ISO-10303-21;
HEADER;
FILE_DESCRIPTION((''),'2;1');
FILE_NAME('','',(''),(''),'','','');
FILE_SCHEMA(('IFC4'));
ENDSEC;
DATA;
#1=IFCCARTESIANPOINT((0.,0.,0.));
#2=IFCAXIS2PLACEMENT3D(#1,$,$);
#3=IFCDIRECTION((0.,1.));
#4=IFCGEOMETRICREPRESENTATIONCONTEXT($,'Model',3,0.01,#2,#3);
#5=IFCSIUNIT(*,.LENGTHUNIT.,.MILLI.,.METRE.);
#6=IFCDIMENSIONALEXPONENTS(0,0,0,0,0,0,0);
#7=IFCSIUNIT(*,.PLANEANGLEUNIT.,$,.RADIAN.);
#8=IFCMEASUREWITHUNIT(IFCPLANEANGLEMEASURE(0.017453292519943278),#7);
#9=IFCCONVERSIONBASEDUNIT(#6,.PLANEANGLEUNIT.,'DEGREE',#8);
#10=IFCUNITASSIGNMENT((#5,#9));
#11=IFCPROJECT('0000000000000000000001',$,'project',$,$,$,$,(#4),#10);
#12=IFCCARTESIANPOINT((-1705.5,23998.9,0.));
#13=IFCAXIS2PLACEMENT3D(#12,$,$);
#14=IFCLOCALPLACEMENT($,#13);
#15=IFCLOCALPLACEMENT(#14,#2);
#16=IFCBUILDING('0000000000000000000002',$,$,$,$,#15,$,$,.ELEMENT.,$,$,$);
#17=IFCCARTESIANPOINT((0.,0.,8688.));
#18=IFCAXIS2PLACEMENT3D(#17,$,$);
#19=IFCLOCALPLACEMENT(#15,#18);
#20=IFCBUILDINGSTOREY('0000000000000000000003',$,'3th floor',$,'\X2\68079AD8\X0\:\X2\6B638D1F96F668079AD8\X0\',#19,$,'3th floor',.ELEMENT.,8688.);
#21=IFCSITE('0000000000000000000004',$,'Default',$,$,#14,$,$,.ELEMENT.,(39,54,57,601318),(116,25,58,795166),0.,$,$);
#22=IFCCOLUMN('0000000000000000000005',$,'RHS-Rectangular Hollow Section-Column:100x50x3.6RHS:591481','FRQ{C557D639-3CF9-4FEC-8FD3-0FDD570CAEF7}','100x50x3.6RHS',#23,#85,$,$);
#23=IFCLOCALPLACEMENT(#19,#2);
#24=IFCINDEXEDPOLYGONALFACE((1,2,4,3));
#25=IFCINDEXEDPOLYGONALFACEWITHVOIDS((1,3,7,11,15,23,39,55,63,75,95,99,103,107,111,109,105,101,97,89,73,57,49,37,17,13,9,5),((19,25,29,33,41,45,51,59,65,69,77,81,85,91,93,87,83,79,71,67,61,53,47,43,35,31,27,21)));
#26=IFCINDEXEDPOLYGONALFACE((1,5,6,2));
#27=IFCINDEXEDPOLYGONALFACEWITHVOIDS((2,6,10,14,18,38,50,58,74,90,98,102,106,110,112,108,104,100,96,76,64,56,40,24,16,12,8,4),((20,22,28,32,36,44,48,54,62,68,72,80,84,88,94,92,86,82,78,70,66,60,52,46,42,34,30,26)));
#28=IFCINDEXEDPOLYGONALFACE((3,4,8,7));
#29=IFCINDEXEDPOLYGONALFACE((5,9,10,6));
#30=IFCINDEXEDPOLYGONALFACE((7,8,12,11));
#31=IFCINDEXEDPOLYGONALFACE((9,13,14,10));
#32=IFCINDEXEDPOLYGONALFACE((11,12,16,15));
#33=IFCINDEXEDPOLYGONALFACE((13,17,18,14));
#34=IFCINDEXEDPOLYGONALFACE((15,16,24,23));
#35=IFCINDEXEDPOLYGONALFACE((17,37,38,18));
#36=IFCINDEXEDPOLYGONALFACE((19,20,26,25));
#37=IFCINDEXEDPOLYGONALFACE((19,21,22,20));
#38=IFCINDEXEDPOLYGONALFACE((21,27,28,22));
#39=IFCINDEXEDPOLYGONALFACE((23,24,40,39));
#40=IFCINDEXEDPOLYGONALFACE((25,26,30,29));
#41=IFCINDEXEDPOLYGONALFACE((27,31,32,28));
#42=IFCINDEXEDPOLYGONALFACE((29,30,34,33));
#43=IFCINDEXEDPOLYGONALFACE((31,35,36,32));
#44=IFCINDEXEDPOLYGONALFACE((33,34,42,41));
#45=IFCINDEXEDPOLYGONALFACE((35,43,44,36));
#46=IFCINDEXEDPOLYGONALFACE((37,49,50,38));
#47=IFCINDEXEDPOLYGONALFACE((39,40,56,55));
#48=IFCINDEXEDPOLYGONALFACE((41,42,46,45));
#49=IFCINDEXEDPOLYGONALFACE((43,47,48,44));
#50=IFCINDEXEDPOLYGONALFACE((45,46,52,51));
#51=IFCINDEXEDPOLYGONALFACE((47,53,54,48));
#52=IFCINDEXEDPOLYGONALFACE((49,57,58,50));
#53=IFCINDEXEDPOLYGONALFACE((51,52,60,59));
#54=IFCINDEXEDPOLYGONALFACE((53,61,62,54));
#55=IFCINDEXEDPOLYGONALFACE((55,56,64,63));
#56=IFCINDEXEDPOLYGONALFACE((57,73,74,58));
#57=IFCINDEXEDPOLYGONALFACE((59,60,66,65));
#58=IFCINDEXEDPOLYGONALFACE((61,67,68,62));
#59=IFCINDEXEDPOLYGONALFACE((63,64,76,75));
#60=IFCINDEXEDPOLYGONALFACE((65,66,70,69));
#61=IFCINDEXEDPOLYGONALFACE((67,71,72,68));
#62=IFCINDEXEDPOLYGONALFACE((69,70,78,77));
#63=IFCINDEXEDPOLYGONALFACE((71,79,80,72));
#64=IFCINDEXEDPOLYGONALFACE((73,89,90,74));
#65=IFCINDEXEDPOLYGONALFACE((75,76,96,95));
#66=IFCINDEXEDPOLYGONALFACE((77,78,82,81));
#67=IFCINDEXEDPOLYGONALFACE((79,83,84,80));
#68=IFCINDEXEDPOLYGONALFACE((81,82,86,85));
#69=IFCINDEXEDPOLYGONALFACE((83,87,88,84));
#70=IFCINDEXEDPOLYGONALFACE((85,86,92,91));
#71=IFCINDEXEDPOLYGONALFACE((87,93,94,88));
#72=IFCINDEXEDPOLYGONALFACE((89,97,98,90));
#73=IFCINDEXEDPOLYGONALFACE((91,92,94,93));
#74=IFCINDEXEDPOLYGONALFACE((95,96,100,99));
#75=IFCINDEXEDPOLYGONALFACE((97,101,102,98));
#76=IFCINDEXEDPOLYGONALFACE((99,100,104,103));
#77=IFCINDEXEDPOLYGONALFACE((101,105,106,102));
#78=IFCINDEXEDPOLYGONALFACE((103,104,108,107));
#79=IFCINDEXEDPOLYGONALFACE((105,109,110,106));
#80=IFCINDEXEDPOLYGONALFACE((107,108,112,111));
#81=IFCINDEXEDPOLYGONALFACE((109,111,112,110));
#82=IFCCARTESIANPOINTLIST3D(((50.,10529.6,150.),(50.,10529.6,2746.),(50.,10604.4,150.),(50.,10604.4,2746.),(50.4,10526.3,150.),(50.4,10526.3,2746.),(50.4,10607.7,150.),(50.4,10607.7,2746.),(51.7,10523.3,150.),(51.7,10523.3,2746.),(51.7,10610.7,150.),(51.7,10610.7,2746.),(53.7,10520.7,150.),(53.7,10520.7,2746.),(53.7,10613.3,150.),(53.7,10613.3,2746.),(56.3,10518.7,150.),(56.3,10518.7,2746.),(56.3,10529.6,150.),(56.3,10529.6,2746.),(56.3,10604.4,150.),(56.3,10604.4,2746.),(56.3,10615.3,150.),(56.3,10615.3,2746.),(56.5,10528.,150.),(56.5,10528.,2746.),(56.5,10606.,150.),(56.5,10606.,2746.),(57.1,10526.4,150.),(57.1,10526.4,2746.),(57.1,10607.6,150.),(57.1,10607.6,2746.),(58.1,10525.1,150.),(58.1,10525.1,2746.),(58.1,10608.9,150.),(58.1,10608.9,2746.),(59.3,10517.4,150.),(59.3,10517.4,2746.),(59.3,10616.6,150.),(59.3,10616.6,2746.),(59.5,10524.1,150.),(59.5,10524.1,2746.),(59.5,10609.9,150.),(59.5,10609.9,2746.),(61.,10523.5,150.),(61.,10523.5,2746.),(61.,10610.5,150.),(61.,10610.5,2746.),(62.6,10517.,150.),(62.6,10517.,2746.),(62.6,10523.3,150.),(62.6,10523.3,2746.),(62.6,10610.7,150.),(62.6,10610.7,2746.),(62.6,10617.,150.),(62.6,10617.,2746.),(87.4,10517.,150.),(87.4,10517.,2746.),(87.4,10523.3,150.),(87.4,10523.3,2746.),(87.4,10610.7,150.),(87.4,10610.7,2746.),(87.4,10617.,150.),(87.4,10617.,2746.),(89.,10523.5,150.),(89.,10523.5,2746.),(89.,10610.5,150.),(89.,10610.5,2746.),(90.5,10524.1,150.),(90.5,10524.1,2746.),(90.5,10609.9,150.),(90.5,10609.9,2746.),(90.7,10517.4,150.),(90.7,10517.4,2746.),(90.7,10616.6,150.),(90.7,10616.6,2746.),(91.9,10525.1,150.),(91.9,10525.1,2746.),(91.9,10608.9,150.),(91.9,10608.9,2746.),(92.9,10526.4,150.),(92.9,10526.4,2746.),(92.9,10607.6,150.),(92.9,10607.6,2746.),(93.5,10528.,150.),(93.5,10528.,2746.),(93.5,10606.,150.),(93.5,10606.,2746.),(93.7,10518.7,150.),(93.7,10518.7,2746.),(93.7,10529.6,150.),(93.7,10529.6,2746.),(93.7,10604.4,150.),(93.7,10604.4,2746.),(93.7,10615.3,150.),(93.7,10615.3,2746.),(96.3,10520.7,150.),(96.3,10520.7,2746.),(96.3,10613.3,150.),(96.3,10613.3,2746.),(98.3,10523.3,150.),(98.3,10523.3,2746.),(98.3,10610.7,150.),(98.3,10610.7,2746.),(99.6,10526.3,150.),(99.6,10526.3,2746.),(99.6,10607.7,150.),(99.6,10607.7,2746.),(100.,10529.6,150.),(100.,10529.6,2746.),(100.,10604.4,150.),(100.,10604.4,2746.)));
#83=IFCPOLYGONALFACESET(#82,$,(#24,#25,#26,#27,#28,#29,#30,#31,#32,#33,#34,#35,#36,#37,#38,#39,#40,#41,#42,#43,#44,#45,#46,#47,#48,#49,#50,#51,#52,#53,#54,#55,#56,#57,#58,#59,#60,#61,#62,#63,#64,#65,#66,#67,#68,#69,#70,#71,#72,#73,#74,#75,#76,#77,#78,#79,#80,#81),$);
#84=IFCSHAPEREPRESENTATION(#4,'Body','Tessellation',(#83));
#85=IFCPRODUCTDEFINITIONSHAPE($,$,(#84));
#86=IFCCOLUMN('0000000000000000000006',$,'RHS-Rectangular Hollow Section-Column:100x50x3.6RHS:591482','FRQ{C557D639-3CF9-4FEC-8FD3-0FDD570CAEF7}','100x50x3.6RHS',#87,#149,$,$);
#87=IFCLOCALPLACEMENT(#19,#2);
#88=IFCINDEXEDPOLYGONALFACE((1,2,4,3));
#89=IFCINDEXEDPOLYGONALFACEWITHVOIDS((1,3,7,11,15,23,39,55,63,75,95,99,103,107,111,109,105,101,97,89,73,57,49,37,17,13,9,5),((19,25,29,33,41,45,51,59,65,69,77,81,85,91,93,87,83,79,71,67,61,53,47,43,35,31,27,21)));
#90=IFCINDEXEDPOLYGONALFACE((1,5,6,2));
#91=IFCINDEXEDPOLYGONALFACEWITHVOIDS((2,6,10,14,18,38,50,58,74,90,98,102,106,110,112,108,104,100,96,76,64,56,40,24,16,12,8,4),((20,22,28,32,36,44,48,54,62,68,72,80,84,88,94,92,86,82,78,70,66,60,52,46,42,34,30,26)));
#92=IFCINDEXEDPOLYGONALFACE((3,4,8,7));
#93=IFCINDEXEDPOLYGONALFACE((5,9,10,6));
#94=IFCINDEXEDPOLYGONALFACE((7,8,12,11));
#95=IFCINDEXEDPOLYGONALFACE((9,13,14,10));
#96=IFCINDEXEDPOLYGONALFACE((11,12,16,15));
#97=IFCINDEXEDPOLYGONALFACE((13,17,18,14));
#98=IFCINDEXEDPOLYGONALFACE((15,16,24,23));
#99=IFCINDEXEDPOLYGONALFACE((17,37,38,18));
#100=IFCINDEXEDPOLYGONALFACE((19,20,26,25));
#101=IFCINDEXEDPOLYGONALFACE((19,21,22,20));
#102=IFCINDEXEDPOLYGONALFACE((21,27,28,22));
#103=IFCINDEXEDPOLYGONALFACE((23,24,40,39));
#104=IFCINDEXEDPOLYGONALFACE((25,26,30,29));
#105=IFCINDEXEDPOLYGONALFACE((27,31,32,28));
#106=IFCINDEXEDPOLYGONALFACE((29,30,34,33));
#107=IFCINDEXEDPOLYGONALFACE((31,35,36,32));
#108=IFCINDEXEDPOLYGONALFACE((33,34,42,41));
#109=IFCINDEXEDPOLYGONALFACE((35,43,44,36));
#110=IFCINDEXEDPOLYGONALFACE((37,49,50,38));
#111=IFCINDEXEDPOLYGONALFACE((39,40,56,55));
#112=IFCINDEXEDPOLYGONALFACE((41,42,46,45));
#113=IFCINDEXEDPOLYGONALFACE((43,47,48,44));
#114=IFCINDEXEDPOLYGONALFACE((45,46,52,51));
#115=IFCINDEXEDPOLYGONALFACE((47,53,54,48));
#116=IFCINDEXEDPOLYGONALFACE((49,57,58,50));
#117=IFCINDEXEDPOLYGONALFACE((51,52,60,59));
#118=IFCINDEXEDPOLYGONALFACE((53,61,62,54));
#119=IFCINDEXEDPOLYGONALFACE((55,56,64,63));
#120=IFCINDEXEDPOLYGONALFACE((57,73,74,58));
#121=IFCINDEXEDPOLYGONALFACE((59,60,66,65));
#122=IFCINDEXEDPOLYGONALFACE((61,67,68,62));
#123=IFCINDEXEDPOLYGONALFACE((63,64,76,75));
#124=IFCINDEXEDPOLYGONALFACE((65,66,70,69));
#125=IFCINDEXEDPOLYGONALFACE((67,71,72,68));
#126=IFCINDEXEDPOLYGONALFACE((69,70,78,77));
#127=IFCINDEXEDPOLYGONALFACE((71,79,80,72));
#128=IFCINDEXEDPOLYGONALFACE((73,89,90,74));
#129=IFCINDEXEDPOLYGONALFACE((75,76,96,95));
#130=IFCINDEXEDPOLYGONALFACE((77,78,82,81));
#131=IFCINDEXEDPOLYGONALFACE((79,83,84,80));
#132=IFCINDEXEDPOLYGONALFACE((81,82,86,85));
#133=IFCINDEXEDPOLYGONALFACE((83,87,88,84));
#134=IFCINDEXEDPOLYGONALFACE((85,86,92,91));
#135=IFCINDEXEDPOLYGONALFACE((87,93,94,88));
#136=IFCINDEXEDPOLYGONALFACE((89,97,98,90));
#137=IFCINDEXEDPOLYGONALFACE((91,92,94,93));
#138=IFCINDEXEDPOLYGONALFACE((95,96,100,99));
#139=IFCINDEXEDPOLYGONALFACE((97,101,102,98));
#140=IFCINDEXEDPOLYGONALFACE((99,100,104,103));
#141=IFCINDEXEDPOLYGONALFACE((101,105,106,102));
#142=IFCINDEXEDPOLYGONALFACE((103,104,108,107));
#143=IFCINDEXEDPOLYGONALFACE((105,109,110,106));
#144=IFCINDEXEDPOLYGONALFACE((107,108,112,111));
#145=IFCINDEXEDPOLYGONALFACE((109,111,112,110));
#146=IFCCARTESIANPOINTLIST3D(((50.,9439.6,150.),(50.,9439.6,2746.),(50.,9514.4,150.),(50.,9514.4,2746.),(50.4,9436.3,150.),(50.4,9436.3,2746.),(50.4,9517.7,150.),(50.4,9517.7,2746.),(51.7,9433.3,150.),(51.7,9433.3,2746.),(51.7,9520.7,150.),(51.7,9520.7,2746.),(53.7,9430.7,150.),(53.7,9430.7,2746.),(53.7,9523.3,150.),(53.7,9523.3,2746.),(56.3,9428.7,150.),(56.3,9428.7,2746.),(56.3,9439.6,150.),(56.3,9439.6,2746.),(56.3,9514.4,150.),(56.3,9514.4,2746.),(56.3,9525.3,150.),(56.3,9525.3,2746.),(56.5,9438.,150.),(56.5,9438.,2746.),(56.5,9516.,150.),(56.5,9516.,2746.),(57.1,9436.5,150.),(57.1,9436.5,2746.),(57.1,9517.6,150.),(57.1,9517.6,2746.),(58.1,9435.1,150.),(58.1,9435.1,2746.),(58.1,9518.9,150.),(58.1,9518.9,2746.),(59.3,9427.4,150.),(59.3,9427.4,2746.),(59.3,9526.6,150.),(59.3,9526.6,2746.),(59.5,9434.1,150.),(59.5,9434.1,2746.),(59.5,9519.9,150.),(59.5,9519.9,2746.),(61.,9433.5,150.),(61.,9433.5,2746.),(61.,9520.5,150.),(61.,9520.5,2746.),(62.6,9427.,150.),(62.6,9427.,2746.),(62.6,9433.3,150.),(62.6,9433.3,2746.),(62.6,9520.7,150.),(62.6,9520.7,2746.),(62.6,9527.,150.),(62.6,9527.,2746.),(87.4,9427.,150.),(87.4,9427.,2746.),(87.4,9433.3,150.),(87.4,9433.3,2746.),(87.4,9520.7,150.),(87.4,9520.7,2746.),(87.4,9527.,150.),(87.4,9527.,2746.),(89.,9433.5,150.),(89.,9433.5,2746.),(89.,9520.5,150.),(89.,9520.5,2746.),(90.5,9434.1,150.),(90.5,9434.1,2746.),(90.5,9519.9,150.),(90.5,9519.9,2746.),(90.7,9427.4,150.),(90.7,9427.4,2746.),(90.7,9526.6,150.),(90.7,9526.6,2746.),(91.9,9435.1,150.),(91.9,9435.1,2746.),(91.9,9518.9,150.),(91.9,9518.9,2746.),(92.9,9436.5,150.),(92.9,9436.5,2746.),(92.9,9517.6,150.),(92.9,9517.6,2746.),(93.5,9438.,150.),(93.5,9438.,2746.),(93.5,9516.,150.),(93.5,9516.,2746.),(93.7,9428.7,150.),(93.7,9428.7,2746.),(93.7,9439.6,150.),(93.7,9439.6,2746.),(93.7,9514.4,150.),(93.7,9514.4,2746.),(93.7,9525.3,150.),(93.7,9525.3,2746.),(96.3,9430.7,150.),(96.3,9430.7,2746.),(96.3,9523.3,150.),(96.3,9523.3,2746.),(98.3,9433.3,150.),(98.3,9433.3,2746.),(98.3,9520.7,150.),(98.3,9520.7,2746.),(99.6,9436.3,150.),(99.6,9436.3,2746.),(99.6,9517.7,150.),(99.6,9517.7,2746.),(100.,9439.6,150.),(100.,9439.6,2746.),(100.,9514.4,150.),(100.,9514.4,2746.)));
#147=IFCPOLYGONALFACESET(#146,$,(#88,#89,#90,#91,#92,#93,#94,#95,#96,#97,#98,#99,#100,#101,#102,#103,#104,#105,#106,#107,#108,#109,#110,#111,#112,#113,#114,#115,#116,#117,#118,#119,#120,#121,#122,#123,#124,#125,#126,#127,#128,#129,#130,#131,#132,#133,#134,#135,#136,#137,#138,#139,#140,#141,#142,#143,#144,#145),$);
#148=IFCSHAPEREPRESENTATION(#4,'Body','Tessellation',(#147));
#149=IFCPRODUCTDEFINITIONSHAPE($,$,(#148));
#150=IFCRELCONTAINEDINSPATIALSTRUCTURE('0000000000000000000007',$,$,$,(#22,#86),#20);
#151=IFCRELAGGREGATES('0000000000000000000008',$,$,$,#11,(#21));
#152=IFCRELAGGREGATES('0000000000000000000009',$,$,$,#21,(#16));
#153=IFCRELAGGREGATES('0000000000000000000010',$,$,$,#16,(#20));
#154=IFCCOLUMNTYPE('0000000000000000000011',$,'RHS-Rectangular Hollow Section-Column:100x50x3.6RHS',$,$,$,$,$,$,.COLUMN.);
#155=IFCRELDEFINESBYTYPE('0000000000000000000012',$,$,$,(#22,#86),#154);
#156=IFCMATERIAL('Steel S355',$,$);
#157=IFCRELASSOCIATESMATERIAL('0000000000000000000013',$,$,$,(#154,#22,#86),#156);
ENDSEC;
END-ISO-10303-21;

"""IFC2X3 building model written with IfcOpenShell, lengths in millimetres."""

from ifc_helpers import new_model, entity, si_unit, converted_unit, point, direction, frame, frame_2d, origin, origin_2d, place, context, project, spatial, circle_curve, line_curve, trimmed, segment, composite_curve, hollow_rectangle, outline, extrude, clip, halfspace, material, type_object, element, save


model = new_model("IFC2X3")

# Units and contexts
model_context = context("Model", 3, precision=0.01, world=origin(), true_north=direction((0.0, 1.0)))
ifc_project = project(units=[si_unit("LENGTHUNIT", "METRE", prefix="MILLI"), converted_unit("PLANEANGLEUNIT", "DEGREE", entity("IfcPlaneAngleMeasure", 0.017453292519943278), si_unit("PLANEANGLEUNIT", "RADIAN"), dimensions=[0, 0, 0, 0, 0, 0, 0])], contexts=[model_context])

# Site, building, storey
site_placement = place(None, frame((-1705.5, 23998.9, 0.0)))
site = spatial("IfcSite", under=ifc_project, at=site_placement, Name="Default", CompositionType="ELEMENT", RefLatitude=(39, 54, 57, 601318), RefLongitude=(116, 25, 58, 795166), RefElevation=0.0)
building_placement = place(site_placement, origin())
building = spatial("IfcBuilding", under=site, at=building_placement, CompositionType="ELEMENT")
storey_placement = place(building_placement, frame((0.0, 0.0, 8688.0)))
storey = spatial("IfcBuildingStorey", under=building, at=storey_placement, Name="3th floor", ObjectType="标高:正负零标高", LongName="3th floor", CompositionType="ELEMENT", Elevation=8688.0)

# Shared definitions
ifc_material_1 = material(Name="Steel S355")

# Columns, openings
column_type_1 = type_object("IfcColumnType", Name="RHS-Rectangular Hollow Section-Column:100x50x3.6RHS", PredefinedType="COLUMN", material=ifc_material_1)
column_1_placement = place(storey_placement, frame((75.0, 10567.0, 2876.9)))
column_1 = element("IfcColumn", 1, at=column_1_placement, inside=storey, type_object=column_type_1, material=ifc_material_1, Name="RHS-Rectangular Hollow Section-Column:100x50x3.6RHS:591481", Description="FRQ{C557D639-3CF9-4FEC-8FD3-0FDD570CAEF7}", ObjectType="100x50x3.6RHS", context=model_context, shape_type="Clipping", body=[
    clip(clip(extrude(hollow_rectangle(XDim=50.0, YDim=100.0, WallThickness=6.3, InnerFilletRadius=6.3, OuterFilletRadius=12.6, at=origin_2d()), origin(), (0.0, 0.0, -1.0), 2782.8), halfspace(frame((-75.0, -10567.0, -55.9), z_axis=(0.0, 0.0, -1.0), x_axis=(-1.0, 0.0, 0.0)), True)), halfspace(frame((-75.0, -10567.0, -2726.9), z_axis=(0.0, 0.0, 1.0), x_axis=(1.0, 0.0, 0.0)), True)),
])
opening_1_placement = place(column_1_placement, frame((0.0, -150.1, -130.9), z_axis=(0.0, 1.0, 0.0), x_axis=(-1.0, 0.0, 0.0)))
element("IfcOpeningElement", 2, at=opening_1_placement, cuts=column_1, ObjectType="Opening", context=model_context, shape_type="SweptSolid", body=[
    extrude(outline(composite_curve([segment(trimmed(circle_curve(frame_2d((43.0, 32.0), x_axis=(1.0, 0.0)), 32.0), [point((43.0, 0.0))], [point((75.0, 32.0))], True, "CARTESIAN"), True, "CONTINUOUS"), segment(trimmed(line_curve((75.0, 32.0), (0.0, 1.0), 86.0), [point((75.0, 32.0))], [point((75.0, 118.0))], True, "CARTESIAN"), True, "CONTINUOUS"), segment(trimmed(circle_curve(frame_2d((43.0, 118.0), x_axis=(1.0, 0.0)), 32.0), [point((75.0, 118.0))], [point((43.0, 150.0))], True, "CARTESIAN"), True, "CONTINUOUS"), segment(trimmed(line_curve((43.0, 150.0), (-1.0, 0.0), 86.0), [point((43.0, 150.0))], [point((-43.0, 150.0))], True, "CARTESIAN"), True, "CONTINUOUS"), segment(trimmed(circle_curve(frame_2d((-43.0, 118.0), x_axis=(1.0, 0.0)), 32.0), [point((-43.0, 150.0))], [point((-75.0, 118.0))], True, "CARTESIAN"), True, "CONTINUOUS"), segment(trimmed(line_curve((-75.0, 118.0), (0.0, -1.0), 86.0), [point((-75.0, 118.0))], [point((-75.0, 32.0))], True, "CARTESIAN"), True, "CONTINUOUS"), segment(trimmed(circle_curve(frame_2d((-43.0, 32.0), x_axis=(1.0, 0.0)), 32.0), [point((-75.0, 32.0))], [point((-43.0, 0.0))], True, "CARTESIAN"), True, "CONTINUOUS"), segment(trimmed(line_curve((-43.0, 0.0), (1.0, 0.0), 86.0), [point((-43.0, 0.0))], [point((43.0, 0.0))], True, "CARTESIAN"), True, "CONTINUOUS")], self_intersect="UNKNOWN")), origin(), (0.0, 0.0, 1.0), 300.2),
])
column_2_placement = place(storey_placement, frame((75.0, 9477.0, 2876.9)))
column_2 = element("IfcColumn", 3, at=column_2_placement, inside=storey, type_object=column_type_1, material=ifc_material_1, Name="RHS-Rectangular Hollow Section-Column:100x50x3.6RHS:591482", Description="FRQ{C557D639-3CF9-4FEC-8FD3-0FDD570CAEF7}", ObjectType="100x50x3.6RHS", context=model_context, shape_type="Clipping", body=[
    clip(clip(extrude(hollow_rectangle(XDim=50.0, YDim=100.0, WallThickness=6.3, InnerFilletRadius=6.3, OuterFilletRadius=12.6, at=origin_2d()), origin(), (0.0, 0.0, -1.0), 2782.8), halfspace(frame((-75.0, -9477.0, -55.9), z_axis=(0.0, 0.0, -1.0), x_axis=(-1.0, 0.0, 0.0)), True)), halfspace(frame((-75.0, -9477.0, -2726.9), z_axis=(0.0, 0.0, 1.0), x_axis=(1.0, 0.0, 0.0)), True)),
])
opening_2_placement = place(column_2_placement, frame((0.0, -150.1, -130.9), z_axis=(0.0, 1.0, 0.0), x_axis=(-1.0, 0.0, 0.0)))
element("IfcOpeningElement", 4, at=opening_2_placement, cuts=column_2, ObjectType="Opening", context=model_context, shape_type="SweptSolid", body=[
    extrude(outline(composite_curve([segment(trimmed(circle_curve(frame_2d((43.0, 32.0), x_axis=(1.0, 0.0)), 32.0), [point((43.0, 0.0))], [point((75.0, 32.0))], True, "CARTESIAN"), True, "CONTINUOUS"), segment(trimmed(line_curve((75.0, 32.0), (0.0, 1.0), 86.0), [point((75.0, 32.0))], [point((75.0, 118.0))], True, "CARTESIAN"), True, "CONTINUOUS"), segment(trimmed(circle_curve(frame_2d((43.0, 118.0), x_axis=(1.0, 0.0)), 32.0), [point((75.0, 118.0))], [point((43.0, 150.0))], True, "CARTESIAN"), True, "CONTINUOUS"), segment(trimmed(line_curve((43.0, 150.0), (-1.0, 0.0), 86.0), [point((43.0, 150.0))], [point((-43.0, 150.0))], True, "CARTESIAN"), True, "CONTINUOUS"), segment(trimmed(circle_curve(frame_2d((-43.0, 118.0), x_axis=(1.0, 0.0)), 32.0), [point((-43.0, 150.0))], [point((-75.0, 118.0))], True, "CARTESIAN"), True, "CONTINUOUS"), segment(trimmed(line_curve((-75.0, 118.0), (0.0, -1.0), 86.0), [point((-75.0, 118.0))], [point((-75.0, 32.0))], True, "CARTESIAN"), True, "CONTINUOUS"), segment(trimmed(circle_curve(frame_2d((-43.0, 32.0), x_axis=(1.0, 0.0)), 32.0), [point((-75.0, 32.0))], [point((-43.0, 0.0))], True, "CARTESIAN"), True, "CONTINUOUS"), segment(trimmed(line_curve((-43.0, 0.0), (1.0, 0.0), 86.0), [point((-43.0, 0.0))], [point((43.0, 0.0))], True, "CARTESIAN"), True, "CONTINUOUS")], self_intersect="UNKNOWN")), origin(), (0.0, 0.0, 1.0), 300.2),
])

save(model, "model.ifc")
